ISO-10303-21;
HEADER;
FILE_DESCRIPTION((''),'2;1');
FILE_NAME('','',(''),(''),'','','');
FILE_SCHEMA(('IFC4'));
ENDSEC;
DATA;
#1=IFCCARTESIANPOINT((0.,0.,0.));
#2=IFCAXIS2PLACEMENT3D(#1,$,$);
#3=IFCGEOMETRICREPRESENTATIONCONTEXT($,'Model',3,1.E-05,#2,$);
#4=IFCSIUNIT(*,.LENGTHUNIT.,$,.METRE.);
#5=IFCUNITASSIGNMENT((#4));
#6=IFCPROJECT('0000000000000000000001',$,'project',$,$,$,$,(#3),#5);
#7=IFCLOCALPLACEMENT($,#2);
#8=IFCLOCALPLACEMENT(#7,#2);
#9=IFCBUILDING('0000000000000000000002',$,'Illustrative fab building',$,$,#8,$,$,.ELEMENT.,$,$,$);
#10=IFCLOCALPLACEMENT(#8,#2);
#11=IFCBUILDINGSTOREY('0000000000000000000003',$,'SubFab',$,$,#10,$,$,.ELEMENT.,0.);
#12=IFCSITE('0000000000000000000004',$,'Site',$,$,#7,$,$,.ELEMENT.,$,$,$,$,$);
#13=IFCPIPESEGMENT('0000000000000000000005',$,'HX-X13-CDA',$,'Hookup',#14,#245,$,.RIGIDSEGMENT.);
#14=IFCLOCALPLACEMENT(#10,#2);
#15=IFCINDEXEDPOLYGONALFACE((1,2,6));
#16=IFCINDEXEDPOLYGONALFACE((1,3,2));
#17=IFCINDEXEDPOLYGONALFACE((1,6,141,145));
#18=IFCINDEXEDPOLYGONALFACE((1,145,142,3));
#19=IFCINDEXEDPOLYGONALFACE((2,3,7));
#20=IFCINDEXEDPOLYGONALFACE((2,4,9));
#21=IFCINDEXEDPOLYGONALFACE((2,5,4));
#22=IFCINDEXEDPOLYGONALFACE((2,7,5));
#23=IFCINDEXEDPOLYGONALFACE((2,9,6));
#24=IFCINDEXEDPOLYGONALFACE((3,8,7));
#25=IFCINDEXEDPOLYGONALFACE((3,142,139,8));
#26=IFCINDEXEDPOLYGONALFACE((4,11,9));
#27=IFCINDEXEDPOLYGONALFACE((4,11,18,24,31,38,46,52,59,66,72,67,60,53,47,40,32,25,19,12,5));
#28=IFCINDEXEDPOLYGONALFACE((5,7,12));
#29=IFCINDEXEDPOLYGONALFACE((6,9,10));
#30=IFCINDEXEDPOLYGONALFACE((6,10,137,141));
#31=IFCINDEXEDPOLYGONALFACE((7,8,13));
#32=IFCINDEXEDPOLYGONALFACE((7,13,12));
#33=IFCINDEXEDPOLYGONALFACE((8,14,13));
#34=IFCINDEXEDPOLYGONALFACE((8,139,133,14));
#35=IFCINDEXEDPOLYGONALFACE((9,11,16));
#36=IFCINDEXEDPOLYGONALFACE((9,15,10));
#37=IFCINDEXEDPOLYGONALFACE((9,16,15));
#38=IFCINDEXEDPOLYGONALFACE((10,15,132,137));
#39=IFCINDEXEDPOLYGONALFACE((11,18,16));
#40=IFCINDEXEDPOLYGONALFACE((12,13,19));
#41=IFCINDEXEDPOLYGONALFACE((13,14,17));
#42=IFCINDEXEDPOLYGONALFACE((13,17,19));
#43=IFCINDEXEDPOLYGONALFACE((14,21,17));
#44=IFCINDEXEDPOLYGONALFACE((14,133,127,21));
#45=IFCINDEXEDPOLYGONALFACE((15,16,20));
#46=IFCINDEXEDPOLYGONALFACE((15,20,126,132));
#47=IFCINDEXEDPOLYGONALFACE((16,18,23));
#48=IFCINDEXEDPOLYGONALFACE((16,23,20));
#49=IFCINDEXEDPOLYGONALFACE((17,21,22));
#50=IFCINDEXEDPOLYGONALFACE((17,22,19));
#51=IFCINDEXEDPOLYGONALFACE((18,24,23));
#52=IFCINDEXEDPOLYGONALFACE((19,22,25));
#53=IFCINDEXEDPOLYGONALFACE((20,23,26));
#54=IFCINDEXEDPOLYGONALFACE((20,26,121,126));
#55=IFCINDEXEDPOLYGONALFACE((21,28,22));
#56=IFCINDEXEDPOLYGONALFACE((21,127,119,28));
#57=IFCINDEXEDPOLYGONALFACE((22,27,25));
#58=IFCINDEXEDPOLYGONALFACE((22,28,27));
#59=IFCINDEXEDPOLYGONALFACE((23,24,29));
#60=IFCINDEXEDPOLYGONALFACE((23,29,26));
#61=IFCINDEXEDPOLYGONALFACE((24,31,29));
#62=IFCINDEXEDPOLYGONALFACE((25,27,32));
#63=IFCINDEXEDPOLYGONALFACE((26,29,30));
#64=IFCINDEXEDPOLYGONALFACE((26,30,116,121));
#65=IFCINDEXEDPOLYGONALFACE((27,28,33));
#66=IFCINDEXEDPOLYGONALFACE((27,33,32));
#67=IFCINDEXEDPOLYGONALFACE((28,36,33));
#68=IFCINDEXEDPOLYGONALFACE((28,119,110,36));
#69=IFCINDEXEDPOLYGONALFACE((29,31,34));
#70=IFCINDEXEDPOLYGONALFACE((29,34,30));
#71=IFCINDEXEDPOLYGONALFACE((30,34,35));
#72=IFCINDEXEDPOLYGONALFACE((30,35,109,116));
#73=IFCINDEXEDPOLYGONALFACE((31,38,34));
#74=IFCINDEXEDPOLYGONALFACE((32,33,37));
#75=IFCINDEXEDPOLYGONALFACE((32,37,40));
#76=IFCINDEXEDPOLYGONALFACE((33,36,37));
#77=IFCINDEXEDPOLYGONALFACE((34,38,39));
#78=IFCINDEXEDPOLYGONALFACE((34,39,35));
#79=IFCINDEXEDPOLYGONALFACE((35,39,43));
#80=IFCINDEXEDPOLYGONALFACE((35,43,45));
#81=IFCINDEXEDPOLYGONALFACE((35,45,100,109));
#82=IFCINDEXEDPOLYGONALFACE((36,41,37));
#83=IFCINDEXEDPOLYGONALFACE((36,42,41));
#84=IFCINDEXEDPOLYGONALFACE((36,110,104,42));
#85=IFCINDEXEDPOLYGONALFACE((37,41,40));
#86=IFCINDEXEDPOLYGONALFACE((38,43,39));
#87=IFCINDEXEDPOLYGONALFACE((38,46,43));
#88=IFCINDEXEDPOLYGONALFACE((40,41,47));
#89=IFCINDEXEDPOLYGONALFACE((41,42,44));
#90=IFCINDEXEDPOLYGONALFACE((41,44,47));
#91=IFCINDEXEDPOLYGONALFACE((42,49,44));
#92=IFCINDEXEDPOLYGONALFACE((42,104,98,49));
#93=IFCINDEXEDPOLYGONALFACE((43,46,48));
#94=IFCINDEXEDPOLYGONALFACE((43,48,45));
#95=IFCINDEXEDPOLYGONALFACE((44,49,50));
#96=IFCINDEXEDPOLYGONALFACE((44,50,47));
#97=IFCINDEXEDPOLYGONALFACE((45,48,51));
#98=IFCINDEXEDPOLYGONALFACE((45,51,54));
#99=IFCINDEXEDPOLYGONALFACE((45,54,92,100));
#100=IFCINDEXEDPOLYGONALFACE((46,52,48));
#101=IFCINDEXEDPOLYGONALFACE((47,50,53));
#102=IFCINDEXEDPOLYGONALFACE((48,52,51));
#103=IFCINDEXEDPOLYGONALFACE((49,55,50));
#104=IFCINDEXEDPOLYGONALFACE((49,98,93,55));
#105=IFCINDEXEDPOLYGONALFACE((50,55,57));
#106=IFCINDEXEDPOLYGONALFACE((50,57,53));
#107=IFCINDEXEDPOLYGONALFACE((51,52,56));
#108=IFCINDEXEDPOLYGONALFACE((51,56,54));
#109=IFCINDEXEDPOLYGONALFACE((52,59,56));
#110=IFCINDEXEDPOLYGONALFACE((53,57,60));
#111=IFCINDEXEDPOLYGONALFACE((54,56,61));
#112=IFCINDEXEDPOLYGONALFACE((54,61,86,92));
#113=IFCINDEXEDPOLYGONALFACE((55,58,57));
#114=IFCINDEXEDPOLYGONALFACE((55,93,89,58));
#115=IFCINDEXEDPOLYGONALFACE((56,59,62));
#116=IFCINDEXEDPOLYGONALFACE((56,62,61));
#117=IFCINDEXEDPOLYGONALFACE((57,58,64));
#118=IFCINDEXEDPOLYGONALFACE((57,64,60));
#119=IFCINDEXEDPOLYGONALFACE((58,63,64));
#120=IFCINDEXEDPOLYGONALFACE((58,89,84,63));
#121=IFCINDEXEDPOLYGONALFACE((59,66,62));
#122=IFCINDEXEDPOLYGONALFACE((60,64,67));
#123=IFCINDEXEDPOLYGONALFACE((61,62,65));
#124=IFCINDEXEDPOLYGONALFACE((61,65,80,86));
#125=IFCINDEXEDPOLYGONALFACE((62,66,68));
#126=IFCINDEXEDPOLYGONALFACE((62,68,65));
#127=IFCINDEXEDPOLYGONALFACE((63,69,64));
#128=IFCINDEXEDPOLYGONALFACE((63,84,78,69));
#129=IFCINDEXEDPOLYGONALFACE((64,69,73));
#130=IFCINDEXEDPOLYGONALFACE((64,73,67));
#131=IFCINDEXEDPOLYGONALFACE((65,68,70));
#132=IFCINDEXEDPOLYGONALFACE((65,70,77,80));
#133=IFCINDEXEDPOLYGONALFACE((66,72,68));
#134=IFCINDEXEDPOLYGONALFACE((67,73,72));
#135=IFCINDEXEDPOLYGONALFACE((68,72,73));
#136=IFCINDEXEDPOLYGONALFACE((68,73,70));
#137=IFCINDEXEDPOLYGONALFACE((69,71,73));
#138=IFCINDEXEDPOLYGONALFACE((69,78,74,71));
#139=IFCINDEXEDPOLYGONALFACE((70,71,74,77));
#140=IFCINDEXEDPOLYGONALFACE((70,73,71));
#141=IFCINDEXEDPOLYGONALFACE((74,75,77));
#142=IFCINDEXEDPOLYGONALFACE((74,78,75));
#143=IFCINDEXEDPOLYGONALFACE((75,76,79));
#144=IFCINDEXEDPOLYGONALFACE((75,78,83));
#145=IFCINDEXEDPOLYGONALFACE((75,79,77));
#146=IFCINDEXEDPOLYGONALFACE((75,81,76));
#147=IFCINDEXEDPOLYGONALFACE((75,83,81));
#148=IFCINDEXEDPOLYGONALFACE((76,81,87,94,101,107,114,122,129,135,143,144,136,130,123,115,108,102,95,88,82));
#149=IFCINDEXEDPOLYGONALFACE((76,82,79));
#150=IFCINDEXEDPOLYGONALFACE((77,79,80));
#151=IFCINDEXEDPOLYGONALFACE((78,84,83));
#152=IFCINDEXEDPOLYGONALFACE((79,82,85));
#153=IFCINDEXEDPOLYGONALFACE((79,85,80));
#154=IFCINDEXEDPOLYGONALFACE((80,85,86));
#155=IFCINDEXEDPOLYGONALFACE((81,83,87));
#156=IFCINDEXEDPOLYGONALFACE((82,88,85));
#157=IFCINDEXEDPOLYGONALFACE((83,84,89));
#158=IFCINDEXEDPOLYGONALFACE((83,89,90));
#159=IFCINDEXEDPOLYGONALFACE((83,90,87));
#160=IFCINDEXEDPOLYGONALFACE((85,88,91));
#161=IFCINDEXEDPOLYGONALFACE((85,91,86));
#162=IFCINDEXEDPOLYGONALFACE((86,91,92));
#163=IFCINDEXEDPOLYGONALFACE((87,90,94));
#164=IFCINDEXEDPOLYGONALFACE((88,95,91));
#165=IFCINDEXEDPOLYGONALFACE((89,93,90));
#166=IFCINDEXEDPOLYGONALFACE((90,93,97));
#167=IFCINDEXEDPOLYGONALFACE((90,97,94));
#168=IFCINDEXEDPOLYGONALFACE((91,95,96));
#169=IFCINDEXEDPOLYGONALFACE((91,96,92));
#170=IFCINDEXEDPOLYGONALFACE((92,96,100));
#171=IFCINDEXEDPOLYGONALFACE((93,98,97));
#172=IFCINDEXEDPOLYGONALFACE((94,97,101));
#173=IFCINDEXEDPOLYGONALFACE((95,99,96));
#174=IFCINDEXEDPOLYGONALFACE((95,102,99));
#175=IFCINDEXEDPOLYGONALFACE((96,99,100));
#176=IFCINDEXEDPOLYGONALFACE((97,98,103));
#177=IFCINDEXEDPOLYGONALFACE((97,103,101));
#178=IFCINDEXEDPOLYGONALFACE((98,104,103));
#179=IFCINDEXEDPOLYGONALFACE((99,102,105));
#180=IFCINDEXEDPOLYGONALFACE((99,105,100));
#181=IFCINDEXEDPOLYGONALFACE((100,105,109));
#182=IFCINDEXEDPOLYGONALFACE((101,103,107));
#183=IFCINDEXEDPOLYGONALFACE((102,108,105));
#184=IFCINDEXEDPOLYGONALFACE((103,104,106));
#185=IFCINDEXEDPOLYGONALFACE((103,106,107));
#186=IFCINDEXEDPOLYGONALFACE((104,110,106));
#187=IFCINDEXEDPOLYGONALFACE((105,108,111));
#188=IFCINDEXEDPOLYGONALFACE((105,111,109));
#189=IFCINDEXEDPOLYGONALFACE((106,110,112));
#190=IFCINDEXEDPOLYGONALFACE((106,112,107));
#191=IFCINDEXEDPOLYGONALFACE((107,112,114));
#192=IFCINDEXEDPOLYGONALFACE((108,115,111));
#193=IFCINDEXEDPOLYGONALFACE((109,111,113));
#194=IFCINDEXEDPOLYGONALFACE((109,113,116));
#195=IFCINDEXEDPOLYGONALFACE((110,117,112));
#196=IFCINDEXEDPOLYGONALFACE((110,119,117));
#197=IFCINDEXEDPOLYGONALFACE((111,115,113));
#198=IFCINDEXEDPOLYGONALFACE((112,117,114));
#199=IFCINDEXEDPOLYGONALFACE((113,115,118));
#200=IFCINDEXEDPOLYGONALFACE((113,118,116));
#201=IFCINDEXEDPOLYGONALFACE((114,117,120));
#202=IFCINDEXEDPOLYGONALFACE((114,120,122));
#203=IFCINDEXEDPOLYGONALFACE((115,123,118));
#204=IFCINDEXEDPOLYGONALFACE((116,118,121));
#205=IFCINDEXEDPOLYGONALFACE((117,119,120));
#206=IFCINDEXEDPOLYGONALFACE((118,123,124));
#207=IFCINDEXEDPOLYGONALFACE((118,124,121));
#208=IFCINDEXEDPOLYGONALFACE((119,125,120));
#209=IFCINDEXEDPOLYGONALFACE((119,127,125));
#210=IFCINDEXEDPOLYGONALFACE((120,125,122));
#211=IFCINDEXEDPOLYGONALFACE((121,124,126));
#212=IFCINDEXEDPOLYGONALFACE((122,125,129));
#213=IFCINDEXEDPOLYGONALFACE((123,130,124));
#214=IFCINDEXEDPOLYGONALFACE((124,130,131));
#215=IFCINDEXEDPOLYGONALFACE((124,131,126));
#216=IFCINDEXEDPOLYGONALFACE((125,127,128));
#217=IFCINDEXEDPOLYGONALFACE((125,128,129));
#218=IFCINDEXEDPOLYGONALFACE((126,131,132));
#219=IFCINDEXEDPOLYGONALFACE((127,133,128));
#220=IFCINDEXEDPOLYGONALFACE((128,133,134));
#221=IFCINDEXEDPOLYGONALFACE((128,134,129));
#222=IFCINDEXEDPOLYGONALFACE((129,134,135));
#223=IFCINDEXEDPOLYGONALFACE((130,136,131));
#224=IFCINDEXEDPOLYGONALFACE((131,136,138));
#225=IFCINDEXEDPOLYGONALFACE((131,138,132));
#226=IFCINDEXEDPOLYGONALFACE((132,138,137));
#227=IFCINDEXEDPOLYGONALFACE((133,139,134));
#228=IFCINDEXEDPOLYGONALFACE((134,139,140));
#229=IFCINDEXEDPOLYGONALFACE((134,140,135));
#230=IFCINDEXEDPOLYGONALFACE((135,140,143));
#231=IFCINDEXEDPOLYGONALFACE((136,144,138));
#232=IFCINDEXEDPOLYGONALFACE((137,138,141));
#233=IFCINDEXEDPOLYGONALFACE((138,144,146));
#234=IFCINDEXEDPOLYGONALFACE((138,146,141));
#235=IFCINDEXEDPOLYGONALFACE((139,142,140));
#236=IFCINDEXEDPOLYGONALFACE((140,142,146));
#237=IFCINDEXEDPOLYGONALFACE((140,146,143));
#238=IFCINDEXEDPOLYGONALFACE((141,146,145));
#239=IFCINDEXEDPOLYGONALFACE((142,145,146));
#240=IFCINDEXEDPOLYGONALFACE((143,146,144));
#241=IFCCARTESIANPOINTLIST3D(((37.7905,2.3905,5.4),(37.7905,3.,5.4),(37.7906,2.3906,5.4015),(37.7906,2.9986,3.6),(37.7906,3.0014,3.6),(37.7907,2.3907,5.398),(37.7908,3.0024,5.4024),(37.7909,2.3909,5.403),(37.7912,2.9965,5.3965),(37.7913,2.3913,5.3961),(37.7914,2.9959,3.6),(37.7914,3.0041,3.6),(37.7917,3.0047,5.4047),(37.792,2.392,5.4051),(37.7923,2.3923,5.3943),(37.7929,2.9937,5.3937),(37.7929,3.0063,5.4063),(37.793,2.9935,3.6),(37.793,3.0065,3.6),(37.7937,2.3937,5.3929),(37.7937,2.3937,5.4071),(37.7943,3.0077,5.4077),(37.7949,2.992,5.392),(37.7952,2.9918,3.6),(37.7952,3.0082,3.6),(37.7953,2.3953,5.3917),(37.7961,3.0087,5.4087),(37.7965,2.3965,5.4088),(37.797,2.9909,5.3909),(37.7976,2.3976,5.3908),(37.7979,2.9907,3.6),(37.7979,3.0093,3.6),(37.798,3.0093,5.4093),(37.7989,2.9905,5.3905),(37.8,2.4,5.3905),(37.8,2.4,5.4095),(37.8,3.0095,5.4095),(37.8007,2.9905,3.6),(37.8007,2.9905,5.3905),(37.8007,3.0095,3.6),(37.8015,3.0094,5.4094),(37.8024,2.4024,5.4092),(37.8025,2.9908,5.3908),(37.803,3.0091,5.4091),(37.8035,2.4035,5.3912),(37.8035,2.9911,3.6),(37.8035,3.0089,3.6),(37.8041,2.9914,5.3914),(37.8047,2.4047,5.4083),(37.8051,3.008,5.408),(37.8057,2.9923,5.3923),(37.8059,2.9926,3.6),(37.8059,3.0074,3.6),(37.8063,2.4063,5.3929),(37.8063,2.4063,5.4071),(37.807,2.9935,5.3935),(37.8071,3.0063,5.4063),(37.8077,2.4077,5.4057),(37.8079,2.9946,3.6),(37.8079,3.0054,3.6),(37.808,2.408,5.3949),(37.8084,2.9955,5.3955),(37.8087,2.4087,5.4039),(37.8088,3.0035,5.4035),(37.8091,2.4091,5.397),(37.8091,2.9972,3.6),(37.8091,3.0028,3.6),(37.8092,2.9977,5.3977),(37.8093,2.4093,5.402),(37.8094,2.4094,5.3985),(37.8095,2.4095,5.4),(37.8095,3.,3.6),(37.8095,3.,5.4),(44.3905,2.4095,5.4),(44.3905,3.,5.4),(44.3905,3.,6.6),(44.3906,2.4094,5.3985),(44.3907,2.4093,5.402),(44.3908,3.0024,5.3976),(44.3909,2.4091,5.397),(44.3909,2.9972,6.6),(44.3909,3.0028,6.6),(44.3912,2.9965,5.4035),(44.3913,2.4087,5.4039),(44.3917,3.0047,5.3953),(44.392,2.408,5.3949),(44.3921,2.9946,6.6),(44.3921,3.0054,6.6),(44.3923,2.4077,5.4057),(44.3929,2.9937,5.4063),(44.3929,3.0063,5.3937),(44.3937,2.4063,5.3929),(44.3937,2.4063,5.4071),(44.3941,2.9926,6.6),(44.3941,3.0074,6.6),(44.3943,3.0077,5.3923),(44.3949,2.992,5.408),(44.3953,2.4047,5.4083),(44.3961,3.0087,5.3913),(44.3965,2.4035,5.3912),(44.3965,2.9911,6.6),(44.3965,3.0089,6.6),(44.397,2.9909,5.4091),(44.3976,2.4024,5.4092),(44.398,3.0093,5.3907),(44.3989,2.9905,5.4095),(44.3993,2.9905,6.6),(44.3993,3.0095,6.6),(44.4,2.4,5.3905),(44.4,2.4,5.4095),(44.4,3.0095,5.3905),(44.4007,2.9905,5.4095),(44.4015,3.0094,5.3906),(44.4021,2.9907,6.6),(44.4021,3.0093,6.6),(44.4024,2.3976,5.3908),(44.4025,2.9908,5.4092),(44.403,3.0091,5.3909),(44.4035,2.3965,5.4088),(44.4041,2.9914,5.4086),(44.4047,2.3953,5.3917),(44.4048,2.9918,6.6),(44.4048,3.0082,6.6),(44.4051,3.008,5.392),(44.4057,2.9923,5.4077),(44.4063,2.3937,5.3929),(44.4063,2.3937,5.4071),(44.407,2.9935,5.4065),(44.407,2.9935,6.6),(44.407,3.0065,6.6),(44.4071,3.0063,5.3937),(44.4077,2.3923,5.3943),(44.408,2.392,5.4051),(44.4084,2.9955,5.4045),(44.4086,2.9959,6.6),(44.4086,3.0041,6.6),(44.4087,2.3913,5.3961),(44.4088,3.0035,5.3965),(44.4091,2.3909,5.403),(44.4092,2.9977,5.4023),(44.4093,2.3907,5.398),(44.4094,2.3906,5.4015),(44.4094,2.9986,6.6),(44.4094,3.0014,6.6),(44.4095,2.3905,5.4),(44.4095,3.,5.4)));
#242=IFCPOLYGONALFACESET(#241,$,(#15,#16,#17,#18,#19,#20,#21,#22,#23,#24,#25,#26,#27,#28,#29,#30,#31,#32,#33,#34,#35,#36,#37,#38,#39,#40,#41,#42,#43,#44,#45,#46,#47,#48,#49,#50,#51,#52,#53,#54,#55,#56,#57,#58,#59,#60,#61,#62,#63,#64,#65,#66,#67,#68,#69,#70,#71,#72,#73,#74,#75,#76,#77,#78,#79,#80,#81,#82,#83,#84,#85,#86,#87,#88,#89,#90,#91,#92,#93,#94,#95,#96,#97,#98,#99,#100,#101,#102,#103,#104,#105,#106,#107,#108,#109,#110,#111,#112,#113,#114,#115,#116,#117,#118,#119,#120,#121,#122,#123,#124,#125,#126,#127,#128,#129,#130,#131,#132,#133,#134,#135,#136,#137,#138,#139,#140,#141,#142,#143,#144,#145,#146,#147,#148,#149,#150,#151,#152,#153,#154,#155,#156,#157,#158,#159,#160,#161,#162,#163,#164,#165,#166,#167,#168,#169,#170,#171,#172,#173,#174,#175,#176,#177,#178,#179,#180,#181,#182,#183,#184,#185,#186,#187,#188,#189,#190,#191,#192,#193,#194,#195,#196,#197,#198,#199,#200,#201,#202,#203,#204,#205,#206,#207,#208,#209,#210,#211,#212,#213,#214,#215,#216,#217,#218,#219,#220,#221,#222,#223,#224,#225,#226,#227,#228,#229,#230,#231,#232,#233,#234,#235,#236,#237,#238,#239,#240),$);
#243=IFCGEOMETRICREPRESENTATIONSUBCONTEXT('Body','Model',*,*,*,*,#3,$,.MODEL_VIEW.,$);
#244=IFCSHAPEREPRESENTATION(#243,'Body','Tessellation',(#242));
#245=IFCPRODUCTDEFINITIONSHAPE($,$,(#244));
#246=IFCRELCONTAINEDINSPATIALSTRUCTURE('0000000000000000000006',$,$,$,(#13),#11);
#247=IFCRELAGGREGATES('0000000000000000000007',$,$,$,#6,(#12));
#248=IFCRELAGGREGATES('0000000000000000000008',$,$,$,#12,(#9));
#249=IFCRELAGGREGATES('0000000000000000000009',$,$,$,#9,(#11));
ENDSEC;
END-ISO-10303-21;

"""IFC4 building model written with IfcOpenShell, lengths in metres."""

from ifc_helpers import new_model, entity, si_unit, origin, place, context, subcontext, project, spatial, element, save


model = new_model("IFC4")

# Units and contexts
model_context = context("Model", 3, precision=1e-05, world=origin())
body_context = subcontext(model_context, "Body", "Model", "MODEL_VIEW")
ifc_project = project(units=[si_unit("LENGTHUNIT", "METRE")], contexts=[model_context])

# Site, building, storey
site_placement = place(None, origin())
site = spatial("IfcSite", under=ifc_project, at=site_placement, Name="Site", CompositionType="ELEMENT")
building_placement = place(site_placement, origin())
building = spatial("IfcBuilding", under=site, at=building_placement, Name="Illustrative fab building", CompositionType="ELEMENT")
storey_placement = place(building_placement, origin())
storey = spatial("IfcBuildingStorey", under=building, at=storey_placement, Name="SubFab", CompositionType="ELEMENT", Elevation=0.0)

# Pipe segment
pipe_segment_1_placement = place(storey_placement, origin())
element("IfcPipeSegment", 1, at=pipe_segment_1_placement, inside=storey, Name="HX-X13-CDA", ObjectType="Hookup", PredefinedType="RIGIDSEGMENT", context=body_context, shape_type="AdvancedSweptSolid", body=[
    entity("IfcSweptDiskSolid", entity("IfcPolyline", [entity("IfcCartesianPoint", [37.8, 3.0, 3.6]), entity("IfcCartesianPoint", [37.8, 3.0, 5.4]), entity("IfcCartesianPoint", [37.8, 2.4, 5.4]), entity("IfcCartesianPoint", [44.4, 2.4, 5.4]), entity("IfcCartesianPoint", [44.4, 3.0, 5.4]), entity("IfcCartesianPoint", [44.4, 3.0, 6.6])]), 0.0095),
])

save(model, "model.ifc")
